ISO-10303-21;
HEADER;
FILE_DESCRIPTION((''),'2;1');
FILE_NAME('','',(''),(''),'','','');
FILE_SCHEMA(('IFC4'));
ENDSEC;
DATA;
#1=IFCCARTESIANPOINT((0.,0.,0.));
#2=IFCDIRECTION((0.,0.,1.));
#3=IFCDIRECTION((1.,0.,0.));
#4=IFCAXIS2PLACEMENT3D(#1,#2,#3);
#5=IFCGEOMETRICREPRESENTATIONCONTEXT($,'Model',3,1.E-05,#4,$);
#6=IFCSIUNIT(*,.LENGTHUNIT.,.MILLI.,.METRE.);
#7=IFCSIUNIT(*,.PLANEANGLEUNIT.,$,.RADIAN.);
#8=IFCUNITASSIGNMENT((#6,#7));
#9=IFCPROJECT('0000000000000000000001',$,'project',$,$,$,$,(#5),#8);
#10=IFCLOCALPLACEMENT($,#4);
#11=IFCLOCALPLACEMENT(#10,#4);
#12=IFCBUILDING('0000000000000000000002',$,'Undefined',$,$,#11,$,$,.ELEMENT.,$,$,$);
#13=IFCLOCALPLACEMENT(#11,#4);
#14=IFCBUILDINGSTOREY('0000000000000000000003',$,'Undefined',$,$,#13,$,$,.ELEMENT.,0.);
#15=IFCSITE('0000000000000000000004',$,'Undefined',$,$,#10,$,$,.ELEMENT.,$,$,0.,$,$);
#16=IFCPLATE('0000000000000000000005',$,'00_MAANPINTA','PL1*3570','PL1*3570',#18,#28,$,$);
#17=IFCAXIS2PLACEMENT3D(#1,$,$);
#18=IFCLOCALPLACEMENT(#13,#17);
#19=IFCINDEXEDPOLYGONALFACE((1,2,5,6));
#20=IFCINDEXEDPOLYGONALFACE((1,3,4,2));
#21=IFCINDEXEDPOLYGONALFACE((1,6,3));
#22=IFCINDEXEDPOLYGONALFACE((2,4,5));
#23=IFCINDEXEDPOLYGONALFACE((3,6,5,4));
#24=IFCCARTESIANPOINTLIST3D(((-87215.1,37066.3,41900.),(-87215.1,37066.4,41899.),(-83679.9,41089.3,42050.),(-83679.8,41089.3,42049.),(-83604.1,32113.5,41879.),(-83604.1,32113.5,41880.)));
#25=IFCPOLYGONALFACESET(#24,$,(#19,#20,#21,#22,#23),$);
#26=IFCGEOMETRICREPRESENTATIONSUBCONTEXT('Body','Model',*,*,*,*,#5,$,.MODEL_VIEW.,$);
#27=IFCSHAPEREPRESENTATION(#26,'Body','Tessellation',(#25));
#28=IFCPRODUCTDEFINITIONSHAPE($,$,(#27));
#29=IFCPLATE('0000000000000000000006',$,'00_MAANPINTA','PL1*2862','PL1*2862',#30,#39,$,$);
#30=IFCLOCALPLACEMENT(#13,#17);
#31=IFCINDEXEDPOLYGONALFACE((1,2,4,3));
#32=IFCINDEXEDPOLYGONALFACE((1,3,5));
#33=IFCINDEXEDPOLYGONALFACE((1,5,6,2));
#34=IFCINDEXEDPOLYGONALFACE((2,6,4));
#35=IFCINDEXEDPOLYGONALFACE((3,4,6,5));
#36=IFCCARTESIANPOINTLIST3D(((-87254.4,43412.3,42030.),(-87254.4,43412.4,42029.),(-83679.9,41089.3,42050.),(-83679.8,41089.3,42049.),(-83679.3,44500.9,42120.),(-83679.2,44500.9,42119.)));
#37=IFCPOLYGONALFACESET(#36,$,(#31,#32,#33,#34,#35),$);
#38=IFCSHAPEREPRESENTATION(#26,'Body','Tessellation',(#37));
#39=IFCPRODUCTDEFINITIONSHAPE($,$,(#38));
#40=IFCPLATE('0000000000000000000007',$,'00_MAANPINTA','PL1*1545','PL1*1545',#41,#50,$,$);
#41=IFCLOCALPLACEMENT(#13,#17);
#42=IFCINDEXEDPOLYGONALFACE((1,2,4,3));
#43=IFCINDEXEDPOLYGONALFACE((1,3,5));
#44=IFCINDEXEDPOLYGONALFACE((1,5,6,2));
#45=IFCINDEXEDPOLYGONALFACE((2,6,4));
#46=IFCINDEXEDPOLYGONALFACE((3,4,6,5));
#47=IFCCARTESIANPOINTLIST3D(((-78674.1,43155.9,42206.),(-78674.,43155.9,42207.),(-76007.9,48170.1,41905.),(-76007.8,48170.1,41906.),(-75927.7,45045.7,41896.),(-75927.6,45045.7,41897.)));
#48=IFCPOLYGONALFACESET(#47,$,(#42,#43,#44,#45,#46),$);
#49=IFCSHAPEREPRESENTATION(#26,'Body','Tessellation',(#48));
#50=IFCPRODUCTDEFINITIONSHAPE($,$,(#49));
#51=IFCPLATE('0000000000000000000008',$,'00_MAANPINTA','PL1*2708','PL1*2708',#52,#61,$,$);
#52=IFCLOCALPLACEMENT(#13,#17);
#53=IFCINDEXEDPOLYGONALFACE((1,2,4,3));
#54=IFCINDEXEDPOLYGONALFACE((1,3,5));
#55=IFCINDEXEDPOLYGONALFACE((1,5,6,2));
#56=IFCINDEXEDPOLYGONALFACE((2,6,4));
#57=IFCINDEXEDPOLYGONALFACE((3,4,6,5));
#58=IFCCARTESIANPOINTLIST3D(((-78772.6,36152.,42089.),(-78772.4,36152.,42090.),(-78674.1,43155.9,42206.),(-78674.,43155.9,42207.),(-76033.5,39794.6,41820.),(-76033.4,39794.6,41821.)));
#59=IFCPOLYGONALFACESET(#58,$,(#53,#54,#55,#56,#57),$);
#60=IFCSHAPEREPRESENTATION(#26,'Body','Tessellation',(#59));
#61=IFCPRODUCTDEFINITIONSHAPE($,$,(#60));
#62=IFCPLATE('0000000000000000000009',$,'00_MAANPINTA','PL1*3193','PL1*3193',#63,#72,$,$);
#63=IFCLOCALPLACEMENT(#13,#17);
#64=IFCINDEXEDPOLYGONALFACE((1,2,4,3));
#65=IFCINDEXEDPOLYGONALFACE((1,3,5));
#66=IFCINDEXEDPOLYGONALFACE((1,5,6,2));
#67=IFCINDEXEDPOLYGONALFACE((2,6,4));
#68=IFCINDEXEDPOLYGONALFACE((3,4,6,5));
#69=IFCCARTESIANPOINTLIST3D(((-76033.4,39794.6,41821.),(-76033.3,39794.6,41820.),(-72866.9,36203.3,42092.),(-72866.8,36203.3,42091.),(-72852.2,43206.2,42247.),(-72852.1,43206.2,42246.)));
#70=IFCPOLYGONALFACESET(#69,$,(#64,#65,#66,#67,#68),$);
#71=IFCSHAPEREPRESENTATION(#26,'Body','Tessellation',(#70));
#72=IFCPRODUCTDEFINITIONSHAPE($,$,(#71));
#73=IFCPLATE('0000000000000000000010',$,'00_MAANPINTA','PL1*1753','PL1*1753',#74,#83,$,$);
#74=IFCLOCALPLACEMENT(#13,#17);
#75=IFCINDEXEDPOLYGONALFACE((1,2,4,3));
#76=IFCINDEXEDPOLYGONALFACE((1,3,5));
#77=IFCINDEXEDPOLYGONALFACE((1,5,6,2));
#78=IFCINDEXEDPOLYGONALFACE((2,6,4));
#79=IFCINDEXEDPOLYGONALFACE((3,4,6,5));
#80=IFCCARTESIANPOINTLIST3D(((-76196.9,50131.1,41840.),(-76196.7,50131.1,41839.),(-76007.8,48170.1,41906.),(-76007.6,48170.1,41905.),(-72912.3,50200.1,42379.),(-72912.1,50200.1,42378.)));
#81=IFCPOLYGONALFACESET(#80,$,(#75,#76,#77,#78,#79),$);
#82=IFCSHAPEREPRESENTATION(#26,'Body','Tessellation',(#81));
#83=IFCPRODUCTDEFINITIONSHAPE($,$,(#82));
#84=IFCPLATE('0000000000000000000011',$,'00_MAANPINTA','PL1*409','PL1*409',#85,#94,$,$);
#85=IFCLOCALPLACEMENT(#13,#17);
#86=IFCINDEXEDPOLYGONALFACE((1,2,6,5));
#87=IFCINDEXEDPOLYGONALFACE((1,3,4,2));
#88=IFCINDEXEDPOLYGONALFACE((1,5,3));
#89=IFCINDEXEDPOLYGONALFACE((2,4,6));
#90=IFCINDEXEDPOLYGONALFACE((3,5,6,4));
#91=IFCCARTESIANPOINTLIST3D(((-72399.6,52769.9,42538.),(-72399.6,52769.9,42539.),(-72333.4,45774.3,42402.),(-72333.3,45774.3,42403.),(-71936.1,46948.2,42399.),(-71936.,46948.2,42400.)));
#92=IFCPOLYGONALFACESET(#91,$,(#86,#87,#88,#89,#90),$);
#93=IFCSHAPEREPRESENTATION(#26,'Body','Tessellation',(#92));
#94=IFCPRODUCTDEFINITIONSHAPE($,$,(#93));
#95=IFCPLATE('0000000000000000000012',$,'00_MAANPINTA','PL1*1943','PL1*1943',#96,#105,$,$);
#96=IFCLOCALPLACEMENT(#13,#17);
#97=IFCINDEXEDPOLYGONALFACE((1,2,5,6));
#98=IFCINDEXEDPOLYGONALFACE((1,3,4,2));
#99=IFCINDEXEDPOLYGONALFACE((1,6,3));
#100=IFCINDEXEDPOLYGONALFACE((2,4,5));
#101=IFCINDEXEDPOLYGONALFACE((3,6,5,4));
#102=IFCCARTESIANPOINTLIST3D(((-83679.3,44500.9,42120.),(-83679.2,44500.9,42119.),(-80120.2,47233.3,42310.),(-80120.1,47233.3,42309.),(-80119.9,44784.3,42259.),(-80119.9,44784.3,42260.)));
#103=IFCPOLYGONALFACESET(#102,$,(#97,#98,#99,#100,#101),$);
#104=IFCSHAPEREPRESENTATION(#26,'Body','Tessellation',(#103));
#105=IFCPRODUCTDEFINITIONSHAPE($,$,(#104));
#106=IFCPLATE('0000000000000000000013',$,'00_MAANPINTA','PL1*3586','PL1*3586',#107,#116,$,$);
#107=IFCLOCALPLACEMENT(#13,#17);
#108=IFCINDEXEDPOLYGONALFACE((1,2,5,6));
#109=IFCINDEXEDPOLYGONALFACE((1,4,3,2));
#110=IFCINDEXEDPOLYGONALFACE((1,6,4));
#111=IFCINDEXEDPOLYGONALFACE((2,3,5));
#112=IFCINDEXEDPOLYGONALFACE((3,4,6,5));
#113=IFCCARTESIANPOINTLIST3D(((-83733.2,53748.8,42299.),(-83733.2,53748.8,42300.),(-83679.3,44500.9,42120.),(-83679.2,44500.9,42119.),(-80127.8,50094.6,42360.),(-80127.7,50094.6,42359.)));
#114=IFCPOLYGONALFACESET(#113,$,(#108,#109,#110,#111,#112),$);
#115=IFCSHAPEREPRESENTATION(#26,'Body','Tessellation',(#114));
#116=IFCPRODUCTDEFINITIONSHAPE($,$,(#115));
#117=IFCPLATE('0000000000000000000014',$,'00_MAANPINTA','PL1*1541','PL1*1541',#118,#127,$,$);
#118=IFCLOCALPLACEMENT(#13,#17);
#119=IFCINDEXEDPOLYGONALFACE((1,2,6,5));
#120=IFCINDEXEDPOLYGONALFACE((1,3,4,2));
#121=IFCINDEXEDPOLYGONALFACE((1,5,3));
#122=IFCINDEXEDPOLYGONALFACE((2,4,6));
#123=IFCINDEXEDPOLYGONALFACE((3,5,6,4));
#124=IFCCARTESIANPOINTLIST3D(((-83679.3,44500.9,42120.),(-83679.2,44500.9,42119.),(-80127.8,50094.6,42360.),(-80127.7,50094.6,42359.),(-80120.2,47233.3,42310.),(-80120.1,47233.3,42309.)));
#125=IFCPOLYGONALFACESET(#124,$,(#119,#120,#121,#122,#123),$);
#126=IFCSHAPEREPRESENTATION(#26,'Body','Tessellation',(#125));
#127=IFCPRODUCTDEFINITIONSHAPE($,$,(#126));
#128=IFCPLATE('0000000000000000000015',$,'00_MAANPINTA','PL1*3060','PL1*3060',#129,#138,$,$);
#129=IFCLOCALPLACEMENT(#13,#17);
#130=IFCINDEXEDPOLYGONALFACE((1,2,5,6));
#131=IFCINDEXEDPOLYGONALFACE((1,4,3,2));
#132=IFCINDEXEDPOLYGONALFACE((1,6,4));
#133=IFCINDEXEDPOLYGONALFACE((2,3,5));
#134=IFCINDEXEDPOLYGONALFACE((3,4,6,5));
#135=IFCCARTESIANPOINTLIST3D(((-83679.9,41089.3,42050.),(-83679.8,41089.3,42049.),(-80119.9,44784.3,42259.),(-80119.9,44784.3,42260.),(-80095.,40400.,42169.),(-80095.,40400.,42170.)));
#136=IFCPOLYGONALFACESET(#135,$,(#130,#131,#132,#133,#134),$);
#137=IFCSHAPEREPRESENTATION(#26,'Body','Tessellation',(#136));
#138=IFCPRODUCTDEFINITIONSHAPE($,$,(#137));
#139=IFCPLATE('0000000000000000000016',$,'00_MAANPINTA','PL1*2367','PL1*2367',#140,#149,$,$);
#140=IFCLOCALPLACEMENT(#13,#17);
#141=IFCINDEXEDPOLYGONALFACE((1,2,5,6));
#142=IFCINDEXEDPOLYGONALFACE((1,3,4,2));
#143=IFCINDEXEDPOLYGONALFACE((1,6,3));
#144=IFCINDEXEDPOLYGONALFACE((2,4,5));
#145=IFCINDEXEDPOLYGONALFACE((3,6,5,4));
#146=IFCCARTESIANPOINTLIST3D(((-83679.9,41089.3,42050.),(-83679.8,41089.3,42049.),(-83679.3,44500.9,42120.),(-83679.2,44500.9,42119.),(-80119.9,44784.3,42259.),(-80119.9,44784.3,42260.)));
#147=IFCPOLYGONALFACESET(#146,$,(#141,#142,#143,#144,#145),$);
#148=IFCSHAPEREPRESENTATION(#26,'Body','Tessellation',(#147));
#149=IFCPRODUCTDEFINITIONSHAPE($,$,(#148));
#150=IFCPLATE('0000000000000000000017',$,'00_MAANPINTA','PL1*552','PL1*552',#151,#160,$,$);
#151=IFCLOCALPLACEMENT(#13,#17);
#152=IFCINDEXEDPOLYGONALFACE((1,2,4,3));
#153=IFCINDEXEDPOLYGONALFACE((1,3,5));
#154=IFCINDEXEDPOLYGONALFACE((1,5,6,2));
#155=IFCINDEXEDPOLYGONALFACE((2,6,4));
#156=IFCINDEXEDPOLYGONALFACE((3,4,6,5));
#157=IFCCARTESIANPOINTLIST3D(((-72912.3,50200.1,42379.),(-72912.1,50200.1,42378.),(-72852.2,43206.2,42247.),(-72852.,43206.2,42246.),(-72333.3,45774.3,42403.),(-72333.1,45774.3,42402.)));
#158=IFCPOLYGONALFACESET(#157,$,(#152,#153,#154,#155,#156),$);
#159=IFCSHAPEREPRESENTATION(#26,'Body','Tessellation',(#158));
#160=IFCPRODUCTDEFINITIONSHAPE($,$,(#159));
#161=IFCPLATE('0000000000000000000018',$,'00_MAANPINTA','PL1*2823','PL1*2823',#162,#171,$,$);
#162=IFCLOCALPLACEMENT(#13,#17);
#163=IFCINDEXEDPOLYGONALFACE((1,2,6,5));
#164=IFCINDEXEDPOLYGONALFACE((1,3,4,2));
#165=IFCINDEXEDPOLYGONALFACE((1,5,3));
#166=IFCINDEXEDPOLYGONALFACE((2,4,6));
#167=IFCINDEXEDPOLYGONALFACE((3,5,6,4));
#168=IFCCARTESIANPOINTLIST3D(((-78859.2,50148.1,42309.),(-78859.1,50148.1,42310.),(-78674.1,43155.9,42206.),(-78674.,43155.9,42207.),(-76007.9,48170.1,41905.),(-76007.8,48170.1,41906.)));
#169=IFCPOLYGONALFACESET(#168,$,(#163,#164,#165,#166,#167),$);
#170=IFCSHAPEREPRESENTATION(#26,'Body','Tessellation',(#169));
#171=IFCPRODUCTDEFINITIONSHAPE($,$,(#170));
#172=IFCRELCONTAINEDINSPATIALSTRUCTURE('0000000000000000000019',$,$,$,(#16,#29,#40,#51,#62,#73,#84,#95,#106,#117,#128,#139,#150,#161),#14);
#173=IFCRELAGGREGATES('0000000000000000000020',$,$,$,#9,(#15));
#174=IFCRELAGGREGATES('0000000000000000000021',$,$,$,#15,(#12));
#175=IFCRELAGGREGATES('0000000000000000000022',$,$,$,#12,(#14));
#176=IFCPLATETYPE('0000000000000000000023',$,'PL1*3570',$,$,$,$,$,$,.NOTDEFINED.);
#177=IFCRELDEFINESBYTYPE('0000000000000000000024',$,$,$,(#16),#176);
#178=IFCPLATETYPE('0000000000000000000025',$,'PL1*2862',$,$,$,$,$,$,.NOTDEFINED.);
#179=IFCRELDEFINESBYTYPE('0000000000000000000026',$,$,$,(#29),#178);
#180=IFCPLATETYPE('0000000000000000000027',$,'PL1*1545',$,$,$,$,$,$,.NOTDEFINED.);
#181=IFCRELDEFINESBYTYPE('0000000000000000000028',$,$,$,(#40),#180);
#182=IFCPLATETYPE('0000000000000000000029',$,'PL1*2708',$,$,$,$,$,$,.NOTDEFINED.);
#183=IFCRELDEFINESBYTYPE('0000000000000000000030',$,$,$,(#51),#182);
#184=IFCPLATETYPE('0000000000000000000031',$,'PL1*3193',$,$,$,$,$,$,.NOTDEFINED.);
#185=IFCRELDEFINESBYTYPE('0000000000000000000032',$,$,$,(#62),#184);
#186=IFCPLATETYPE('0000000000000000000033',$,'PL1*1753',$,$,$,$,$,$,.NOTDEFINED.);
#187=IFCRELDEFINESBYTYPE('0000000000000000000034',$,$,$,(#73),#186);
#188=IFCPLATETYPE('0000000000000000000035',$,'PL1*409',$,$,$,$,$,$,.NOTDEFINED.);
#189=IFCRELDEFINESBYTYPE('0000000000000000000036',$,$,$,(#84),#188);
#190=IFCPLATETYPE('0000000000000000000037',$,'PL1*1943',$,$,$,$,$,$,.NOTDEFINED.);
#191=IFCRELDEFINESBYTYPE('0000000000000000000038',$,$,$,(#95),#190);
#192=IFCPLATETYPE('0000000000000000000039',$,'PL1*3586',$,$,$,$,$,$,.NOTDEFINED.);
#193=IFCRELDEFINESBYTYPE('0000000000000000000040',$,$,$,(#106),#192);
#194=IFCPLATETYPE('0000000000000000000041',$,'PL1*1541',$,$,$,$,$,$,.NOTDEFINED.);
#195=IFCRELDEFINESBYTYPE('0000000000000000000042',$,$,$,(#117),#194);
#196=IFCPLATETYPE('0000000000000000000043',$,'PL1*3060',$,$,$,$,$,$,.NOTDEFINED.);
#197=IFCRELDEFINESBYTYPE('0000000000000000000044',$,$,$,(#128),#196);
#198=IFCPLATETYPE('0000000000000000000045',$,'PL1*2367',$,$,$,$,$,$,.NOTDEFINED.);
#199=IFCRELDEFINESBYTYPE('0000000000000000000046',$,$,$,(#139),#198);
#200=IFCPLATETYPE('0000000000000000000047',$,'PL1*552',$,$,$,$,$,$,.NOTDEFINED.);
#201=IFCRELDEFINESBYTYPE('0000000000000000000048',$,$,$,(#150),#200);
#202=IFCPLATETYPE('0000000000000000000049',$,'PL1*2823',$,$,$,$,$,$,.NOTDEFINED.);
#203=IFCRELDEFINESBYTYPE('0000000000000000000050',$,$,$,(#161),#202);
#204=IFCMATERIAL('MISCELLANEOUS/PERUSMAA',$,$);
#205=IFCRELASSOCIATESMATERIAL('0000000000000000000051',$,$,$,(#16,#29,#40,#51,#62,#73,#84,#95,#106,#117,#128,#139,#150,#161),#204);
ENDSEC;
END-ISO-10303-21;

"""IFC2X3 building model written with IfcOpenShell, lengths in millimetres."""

from ifc_helpers import new_model, si_unit, frame, origin_with_axes, place, context, subcontext, project, spatial, polyline, outline, extrude, material, type_object, element, save


model = new_model("IFC2X3")

# Units and contexts
model_context = context("Model", 3, precision=1e-05, world=origin_with_axes())
body_context = subcontext(model_context, "Body", "Model", "MODEL_VIEW")
ifc_project = project(units=[si_unit("LENGTHUNIT", "METRE", prefix="MILLI"), si_unit("PLANEANGLEUNIT", "RADIAN")], contexts=[model_context])

# Site, building, storey
site_placement = place(None, origin_with_axes())
site = spatial("IfcSite", under=ifc_project, at=site_placement, Name="Undefined", CompositionType="ELEMENT", RefElevation=0.0)
building_placement = place(site_placement, origin_with_axes())
building = spatial("IfcBuilding", under=site, at=building_placement, Name="Undefined", CompositionType="ELEMENT")
storey_placement = place(building_placement, origin_with_axes())
storey = spatial("IfcBuildingStorey", under=building, at=storey_placement, Name="Undefined", CompositionType="ELEMENT", Elevation=0.0)

# Plates
ifc_material = material(Name="MISCELLANEOUS/PERUSMAA")
plate_type_1 = type_object("IfcPlateType", Name="PL1*3570", PredefinedType="NOTDEFINED")
plate_1_placement = place(storey_placement, frame((-83679.9, 41089.3, 42049.5), z_axis=(0.02067, 0.019107, -0.999604), x_axis=(0.008442, -0.999785, -0.018936)))
element("IfcPlate", 1, at=plate_1_placement, inside=storey, type_object=plate_type_1, material=ifc_material, Name="00_MAANPINTA", Description="PL1*3570", ObjectType="PL1*3570", context=body_context, shape_type="SweptSolid", body=[
    extrude(outline(polyline([(0.0, 0.0), (8977.8, 0.0), (3995.1, 3569.8), (0.0, 0.0)])), frame((0.0, 0.0, -0.5), z_axis=(0.0, 0.0, 1.0), x_axis=(1.0, 0.0, 0.0)), (0.0, 0.0, 1.0), 1.0),
])
plate_type_2 = type_object("IfcPlateType", Name="PL1*2862", PredefinedType="NOTDEFINED")
plate_2_placement = place(storey_placement, frame((-83679.2, 44500.9, 42119.5), z_axis=(0.01892, 0.020507, -0.999611), x_axis=(-0.000178, -0.99979, -0.020514)))
element("IfcPlate", 2, at=plate_2_placement, inside=storey, type_object=plate_type_2, material=ifc_material, Name="00_MAANPINTA", Description="PL1*2862", ObjectType="PL1*2862", context=body_context, shape_type="SweptSolid", body=[
    extrude(outline(polyline([(0.0, 0.0), (3412.3, 0.0), (1090.8, 3575.6), (0.0, 0.0)])), frame((0.0, 0.0, -0.5), z_axis=(0.0, 0.0, 1.0), x_axis=(1.0, 0.0, 0.0)), (0.0, 0.0, 1.0), 1.0),
])
plate_type_3 = type_object("IfcPlateType", Name="PL1*1545", PredefinedType="NOTDEFINED")
plate_3_placement = place(storey_placement, frame((-76007.9, 48170.1, 41905.5), z_axis=(-0.112154, -0.000015, -0.993691), x_axis=(0.025651, -0.999667, -0.00288)))
element("IfcPlate", 3, at=plate_3_placement, inside=storey, type_object=plate_type_3, material=ifc_material, Name="00_MAANPINTA", Description="PL1*1545", ObjectType="PL1*1545", context=body_context, shape_type="SweptSolid", body=[
    extrude(outline(polyline([(0.0, 0.0), (3125.4, 0.0), (4943.3, 2811.7), (0.0, 0.0)])), frame((0.0, 0.0, -0.5), z_axis=(0.0, 0.0, 1.0), x_axis=(1.0, 0.0, 0.0)), (0.0, 0.0, 1.0), 1.0),
])
plate_type_4 = type_object("IfcPlateType", Name="PL1*2708", PredefinedType="NOTDEFINED")
plate_4_placement = place(storey_placement, frame((-76033.4, 39794.6, 41820.5), z_axis=(-0.121784, 0.018289, -0.992388), x_axis=(-0.599956, -0.797861, 0.058921)))
element("IfcPlate", 4, at=plate_4_placement, inside=storey, type_object=plate_type_4, material=ifc_material, Name="00_MAANPINTA", Description="PL1*2708", ObjectType="PL1*2708", context=body_context, shape_type="SweptSolid", body=[
    extrude(outline(polyline([(0.0, 0.0), (4565.4, 0.0), (-1074.9, 4155.1), (0.0, 0.0)])), frame((0.0, 0.0, -0.5), z_axis=(0.0, 0.0, 1.0), x_axis=(1.0, 0.0, 0.0)), (0.0, 0.0, 1.0), 1.0),
])
plate_type_5 = type_object("IfcPlateType", Name="PL1*3193", PredefinedType="NOTDEFINED")
plate_5_placement = place(storey_placement, frame((-72852.1, 43206.2, 42246.5), z_axis=(0.10973, 0.021765, -0.993723), x_axis=(-0.002093, -0.999753, -0.022128)))
element("IfcPlate", 5, at=plate_5_placement, inside=storey, type_object=plate_type_5, material=ifc_material, Name="00_MAANPINTA", Description="PL1*3193", ObjectType="PL1*3193", context=body_context, shape_type="SweptSolid", body=[
    extrude(outline(polyline([(0.0, 0.0), (7004.7, 0.0), (3426.9, 3193.3), (0.0, 0.0)])), frame((0.0, 0.0, -0.5), z_axis=(0.0, 0.0, 1.0), x_axis=(1.0, 0.0, 0.0)), (0.0, 0.0, 1.0), 1.0),
])
plate_type_6 = type_object("IfcPlateType", Name="PL1*1753", PredefinedType="NOTDEFINED")
plate_6_placement = place(storey_placement, frame((-76007.7, 48170.1, 41905.5), z_axis=(0.162268, -0.01756, -0.98659), x_axis=(-0.095914, 0.994826, -0.033482)))
element("IfcPlate", 6, at=plate_6_placement, inside=storey, type_object=plate_type_6, material=ifc_material, Name="00_MAANPINTA", Description="PL1*1753", ObjectType="PL1*1753", context=body_context, shape_type="SweptSolid", body=[
    extrude(outline(polyline([(0.0, 0.0), (1971.2, 0.0), (1706.8, 3318.7), (0.0, 0.0)])), frame((0.0, 0.0, -0.5), z_axis=(0.0, 0.0, 1.0), x_axis=(1.0, 0.0, 0.0)), (0.0, 0.0, 1.0), 1.0),
])
plate_type_7 = type_object("IfcPlateType", Name="PL1*409", PredefinedType="NOTDEFINED")
plate_7_placement = place(storey_placement, frame((-72333.3, 45774.3, 42402.5), z_axis=(-0.063089, 0.018801, -0.997831), x_axis=(-0.009472, 0.999766, 0.019436)))
element("IfcPlate", 7, at=plate_7_placement, inside=storey, type_object=plate_type_7, material=ifc_material, Name="00_MAANPINTA", Description="PL1*409", ObjectType="PL1*409", context=body_context, shape_type="SweptSolid", body=[
    extrude(outline(polyline([(0.0, 0.0), (6997.2, 0.0), (1169.8, 409.2), (0.0, 0.0)])), frame((0.0, 0.0, -0.5), z_axis=(0.0, 0.0, 1.0), x_axis=(1.0, 0.0, 0.0)), (0.0, 0.0, 1.0), 1.0),
])
plate_type_8 = type_object("IfcPlateType", Name="PL1*1943", PredefinedType="NOTDEFINED")
plate_8_placement = place(storey_placement, frame((-80120.2, 47233.3, 42309.5), z_axis=(0.037672, 0.020402, -0.999082), x_axis=(0.00011, -0.999792, -0.020412)))
element("IfcPlate", 8, at=plate_8_placement, inside=storey, type_object=plate_type_8, material=ifc_material, Name="00_MAANPINTA", Description="PL1*1943", ObjectType="PL1*1943", context=body_context, shape_type="SweptSolid", body=[
    extrude(outline(polyline([(0.0, 0.0), (2449.5, 0.0), (2735.3, 3561.9), (0.0, 0.0)])), frame((0.0, 0.0, -0.5), z_axis=(0.0, 0.0, 1.0), x_axis=(1.0, 0.0, 0.0)), (0.0, 0.0, 1.0), 1.0),
])
plate_type_9 = type_object("IfcPlateType", Name="PL1*3586", PredefinedType="NOTDEFINED")
plate_9_placement = place(storey_placement, frame((-83679.2, 44500.9, 42119.5), z_axis=(0.036553, 0.01966, -0.999138), x_axis=(-0.005831, 0.999794, 0.01946)))
element("IfcPlate", 9, at=plate_9_placement, inside=storey, type_object=plate_type_9, material=ifc_material, Name="00_MAANPINTA", Description="PL1*3586", ObjectType="PL1*3586", context=body_context, shape_type="SweptSolid", body=[
    extrude(outline(polyline([(0.0, 0.0), (9249.8, 0.0), (5576.5, 3586.5), (0.0, 0.0)])), frame((0.0, 0.0, -0.5), z_axis=(0.0, 0.0, 1.0), x_axis=(1.0, 0.0, 0.0)), (0.0, 0.0, 1.0), 1.0),
])
plate_type_10 = type_object("IfcPlateType", Name="PL1*1541", PredefinedType="NOTDEFINED")
plate_10_placement = place(storey_placement, frame((-80127.7, 50094.6, 42359.5), z_axis=(0.03985, 0.017564, -0.999051), x_axis=(0.002649, -0.999844, -0.017472)))
element("IfcPlate", 10, at=plate_10_placement, inside=storey, type_object=plate_type_10, material=ifc_material, Name="00_MAANPINTA", Description="PL1*1541", ObjectType="PL1*1541", context=body_context, shape_type="SweptSolid", body=[
    extrude(outline(polyline([(0.0, 0.0), (2861.7, 0.0), (5587.6, 3569.2), (0.0, 0.0)])), frame((0.0, 0.0, -0.5), z_axis=(0.0, 0.0, 1.0), x_axis=(1.0, 0.0, 0.0)), (0.0, 0.0, 1.0), 1.0),
])
plate_type_11 = type_object("IfcPlateType", Name="PL1*3060", PredefinedType="NOTDEFINED")
plate_11_placement = place(storey_placement, frame((-80119.9, 44784.3, 42259.5), z_axis=(0.037428, 0.020721, -0.999084), x_axis=(0.005678, -0.999773, -0.020523)))
element("IfcPlate", 11, at=plate_11_placement, inside=storey, type_object=plate_type_11, material=ifc_material, Name="00_MAANPINTA", Description="PL1*3060", ObjectType="PL1*3060", context=body_context, shape_type="SweptSolid", body=[
    extrude(outline(polyline([(0.0, 0.0), (4385.3, 0.0), (3678.2, 3583.4), (0.0, 0.0)])), frame((0.0, 0.0, -0.5), z_axis=(0.0, 0.0, 1.0), x_axis=(1.0, 0.0, 0.0)), (0.0, 0.0, 1.0), 1.0),
])
plate_type_12 = type_object("IfcPlateType", Name="PL1*2367", PredefinedType="NOTDEFINED")
plate_12_placement = place(storey_placement, frame((-83679.8, 41089.3, 42049.5), z_axis=(0.037665, 0.020493, -0.99908), x_axis=(0.000178, 0.99979, 0.020514)))
element("IfcPlate", 12, at=plate_12_placement, inside=storey, type_object=plate_type_12, material=ifc_material, Name="00_MAANPINTA", Description="PL1*2367", ObjectType="PL1*2367", context=body_context, shape_type="SweptSolid", body=[
    extrude(outline(polyline([(0.0, 0.0), (3412.3, 0.0), (3699.1, 3561.8), (0.0, 0.0)])), frame((0.0, 0.0, -0.5), z_axis=(0.0, 0.0, 1.0), x_axis=(1.0, 0.0, 0.0)), (0.0, 0.0, 1.0), 1.0),
])
plate_type_13 = type_object("IfcPlateType", Name="PL1*552", PredefinedType="NOTDEFINED")
plate_13_placement = place(storey_placement, frame((-72852.1, 43206.2, 42246.5), z_axis=(0.194919, 0.020182, -0.980612), x_axis=(-0.008589, 0.999785, 0.018869)))
element("IfcPlate", 13, at=plate_13_placement, inside=storey, type_object=plate_type_13, material=ifc_material, Name="00_MAANPINTA", Description="PL1*552", ObjectType="PL1*552", context=body_context, shape_type="SweptSolid", body=[
    extrude(outline(polyline([(0.0, 0.0), (6995.4, 0.0), (2566.1, 551.5), (0.0, 0.0)])), frame((0.0, 0.0, -0.5), z_axis=(0.0, 0.0, 1.0), x_axis=(1.0, 0.0, 0.0)), (0.0, 0.0, 1.0), 1.0),
])
plate_type_14 = type_object("IfcPlateType", Name="PL1*2823", PredefinedType="NOTDEFINED")
plate_14_placement = place(storey_placement, frame((-76007.9, 48170.1, 41905.5), z_axis=(-0.132738, 0.011086, -0.991089), x_axis=(-0.468824, -0.881704, 0.052928)))
element("IfcPlate", 14, at=plate_14_placement, inside=storey, type_object=plate_type_14, material=ifc_material, Name="00_MAANPINTA", Description="PL1*2823", ObjectType="PL1*2823", context=body_context, shape_type="SweptSolid", body=[
    extrude(outline(polyline([(0.0, 0.0), (5687.0, 0.0), (-385.9, 3472.3), (0.0, 0.0)])), frame((0.0, 0.0, -0.5), z_axis=(0.0, 0.0, 1.0), x_axis=(1.0, 0.0, 0.0)), (0.0, 0.0, 1.0), 1.0),
])

save(model, "model.ifc")
